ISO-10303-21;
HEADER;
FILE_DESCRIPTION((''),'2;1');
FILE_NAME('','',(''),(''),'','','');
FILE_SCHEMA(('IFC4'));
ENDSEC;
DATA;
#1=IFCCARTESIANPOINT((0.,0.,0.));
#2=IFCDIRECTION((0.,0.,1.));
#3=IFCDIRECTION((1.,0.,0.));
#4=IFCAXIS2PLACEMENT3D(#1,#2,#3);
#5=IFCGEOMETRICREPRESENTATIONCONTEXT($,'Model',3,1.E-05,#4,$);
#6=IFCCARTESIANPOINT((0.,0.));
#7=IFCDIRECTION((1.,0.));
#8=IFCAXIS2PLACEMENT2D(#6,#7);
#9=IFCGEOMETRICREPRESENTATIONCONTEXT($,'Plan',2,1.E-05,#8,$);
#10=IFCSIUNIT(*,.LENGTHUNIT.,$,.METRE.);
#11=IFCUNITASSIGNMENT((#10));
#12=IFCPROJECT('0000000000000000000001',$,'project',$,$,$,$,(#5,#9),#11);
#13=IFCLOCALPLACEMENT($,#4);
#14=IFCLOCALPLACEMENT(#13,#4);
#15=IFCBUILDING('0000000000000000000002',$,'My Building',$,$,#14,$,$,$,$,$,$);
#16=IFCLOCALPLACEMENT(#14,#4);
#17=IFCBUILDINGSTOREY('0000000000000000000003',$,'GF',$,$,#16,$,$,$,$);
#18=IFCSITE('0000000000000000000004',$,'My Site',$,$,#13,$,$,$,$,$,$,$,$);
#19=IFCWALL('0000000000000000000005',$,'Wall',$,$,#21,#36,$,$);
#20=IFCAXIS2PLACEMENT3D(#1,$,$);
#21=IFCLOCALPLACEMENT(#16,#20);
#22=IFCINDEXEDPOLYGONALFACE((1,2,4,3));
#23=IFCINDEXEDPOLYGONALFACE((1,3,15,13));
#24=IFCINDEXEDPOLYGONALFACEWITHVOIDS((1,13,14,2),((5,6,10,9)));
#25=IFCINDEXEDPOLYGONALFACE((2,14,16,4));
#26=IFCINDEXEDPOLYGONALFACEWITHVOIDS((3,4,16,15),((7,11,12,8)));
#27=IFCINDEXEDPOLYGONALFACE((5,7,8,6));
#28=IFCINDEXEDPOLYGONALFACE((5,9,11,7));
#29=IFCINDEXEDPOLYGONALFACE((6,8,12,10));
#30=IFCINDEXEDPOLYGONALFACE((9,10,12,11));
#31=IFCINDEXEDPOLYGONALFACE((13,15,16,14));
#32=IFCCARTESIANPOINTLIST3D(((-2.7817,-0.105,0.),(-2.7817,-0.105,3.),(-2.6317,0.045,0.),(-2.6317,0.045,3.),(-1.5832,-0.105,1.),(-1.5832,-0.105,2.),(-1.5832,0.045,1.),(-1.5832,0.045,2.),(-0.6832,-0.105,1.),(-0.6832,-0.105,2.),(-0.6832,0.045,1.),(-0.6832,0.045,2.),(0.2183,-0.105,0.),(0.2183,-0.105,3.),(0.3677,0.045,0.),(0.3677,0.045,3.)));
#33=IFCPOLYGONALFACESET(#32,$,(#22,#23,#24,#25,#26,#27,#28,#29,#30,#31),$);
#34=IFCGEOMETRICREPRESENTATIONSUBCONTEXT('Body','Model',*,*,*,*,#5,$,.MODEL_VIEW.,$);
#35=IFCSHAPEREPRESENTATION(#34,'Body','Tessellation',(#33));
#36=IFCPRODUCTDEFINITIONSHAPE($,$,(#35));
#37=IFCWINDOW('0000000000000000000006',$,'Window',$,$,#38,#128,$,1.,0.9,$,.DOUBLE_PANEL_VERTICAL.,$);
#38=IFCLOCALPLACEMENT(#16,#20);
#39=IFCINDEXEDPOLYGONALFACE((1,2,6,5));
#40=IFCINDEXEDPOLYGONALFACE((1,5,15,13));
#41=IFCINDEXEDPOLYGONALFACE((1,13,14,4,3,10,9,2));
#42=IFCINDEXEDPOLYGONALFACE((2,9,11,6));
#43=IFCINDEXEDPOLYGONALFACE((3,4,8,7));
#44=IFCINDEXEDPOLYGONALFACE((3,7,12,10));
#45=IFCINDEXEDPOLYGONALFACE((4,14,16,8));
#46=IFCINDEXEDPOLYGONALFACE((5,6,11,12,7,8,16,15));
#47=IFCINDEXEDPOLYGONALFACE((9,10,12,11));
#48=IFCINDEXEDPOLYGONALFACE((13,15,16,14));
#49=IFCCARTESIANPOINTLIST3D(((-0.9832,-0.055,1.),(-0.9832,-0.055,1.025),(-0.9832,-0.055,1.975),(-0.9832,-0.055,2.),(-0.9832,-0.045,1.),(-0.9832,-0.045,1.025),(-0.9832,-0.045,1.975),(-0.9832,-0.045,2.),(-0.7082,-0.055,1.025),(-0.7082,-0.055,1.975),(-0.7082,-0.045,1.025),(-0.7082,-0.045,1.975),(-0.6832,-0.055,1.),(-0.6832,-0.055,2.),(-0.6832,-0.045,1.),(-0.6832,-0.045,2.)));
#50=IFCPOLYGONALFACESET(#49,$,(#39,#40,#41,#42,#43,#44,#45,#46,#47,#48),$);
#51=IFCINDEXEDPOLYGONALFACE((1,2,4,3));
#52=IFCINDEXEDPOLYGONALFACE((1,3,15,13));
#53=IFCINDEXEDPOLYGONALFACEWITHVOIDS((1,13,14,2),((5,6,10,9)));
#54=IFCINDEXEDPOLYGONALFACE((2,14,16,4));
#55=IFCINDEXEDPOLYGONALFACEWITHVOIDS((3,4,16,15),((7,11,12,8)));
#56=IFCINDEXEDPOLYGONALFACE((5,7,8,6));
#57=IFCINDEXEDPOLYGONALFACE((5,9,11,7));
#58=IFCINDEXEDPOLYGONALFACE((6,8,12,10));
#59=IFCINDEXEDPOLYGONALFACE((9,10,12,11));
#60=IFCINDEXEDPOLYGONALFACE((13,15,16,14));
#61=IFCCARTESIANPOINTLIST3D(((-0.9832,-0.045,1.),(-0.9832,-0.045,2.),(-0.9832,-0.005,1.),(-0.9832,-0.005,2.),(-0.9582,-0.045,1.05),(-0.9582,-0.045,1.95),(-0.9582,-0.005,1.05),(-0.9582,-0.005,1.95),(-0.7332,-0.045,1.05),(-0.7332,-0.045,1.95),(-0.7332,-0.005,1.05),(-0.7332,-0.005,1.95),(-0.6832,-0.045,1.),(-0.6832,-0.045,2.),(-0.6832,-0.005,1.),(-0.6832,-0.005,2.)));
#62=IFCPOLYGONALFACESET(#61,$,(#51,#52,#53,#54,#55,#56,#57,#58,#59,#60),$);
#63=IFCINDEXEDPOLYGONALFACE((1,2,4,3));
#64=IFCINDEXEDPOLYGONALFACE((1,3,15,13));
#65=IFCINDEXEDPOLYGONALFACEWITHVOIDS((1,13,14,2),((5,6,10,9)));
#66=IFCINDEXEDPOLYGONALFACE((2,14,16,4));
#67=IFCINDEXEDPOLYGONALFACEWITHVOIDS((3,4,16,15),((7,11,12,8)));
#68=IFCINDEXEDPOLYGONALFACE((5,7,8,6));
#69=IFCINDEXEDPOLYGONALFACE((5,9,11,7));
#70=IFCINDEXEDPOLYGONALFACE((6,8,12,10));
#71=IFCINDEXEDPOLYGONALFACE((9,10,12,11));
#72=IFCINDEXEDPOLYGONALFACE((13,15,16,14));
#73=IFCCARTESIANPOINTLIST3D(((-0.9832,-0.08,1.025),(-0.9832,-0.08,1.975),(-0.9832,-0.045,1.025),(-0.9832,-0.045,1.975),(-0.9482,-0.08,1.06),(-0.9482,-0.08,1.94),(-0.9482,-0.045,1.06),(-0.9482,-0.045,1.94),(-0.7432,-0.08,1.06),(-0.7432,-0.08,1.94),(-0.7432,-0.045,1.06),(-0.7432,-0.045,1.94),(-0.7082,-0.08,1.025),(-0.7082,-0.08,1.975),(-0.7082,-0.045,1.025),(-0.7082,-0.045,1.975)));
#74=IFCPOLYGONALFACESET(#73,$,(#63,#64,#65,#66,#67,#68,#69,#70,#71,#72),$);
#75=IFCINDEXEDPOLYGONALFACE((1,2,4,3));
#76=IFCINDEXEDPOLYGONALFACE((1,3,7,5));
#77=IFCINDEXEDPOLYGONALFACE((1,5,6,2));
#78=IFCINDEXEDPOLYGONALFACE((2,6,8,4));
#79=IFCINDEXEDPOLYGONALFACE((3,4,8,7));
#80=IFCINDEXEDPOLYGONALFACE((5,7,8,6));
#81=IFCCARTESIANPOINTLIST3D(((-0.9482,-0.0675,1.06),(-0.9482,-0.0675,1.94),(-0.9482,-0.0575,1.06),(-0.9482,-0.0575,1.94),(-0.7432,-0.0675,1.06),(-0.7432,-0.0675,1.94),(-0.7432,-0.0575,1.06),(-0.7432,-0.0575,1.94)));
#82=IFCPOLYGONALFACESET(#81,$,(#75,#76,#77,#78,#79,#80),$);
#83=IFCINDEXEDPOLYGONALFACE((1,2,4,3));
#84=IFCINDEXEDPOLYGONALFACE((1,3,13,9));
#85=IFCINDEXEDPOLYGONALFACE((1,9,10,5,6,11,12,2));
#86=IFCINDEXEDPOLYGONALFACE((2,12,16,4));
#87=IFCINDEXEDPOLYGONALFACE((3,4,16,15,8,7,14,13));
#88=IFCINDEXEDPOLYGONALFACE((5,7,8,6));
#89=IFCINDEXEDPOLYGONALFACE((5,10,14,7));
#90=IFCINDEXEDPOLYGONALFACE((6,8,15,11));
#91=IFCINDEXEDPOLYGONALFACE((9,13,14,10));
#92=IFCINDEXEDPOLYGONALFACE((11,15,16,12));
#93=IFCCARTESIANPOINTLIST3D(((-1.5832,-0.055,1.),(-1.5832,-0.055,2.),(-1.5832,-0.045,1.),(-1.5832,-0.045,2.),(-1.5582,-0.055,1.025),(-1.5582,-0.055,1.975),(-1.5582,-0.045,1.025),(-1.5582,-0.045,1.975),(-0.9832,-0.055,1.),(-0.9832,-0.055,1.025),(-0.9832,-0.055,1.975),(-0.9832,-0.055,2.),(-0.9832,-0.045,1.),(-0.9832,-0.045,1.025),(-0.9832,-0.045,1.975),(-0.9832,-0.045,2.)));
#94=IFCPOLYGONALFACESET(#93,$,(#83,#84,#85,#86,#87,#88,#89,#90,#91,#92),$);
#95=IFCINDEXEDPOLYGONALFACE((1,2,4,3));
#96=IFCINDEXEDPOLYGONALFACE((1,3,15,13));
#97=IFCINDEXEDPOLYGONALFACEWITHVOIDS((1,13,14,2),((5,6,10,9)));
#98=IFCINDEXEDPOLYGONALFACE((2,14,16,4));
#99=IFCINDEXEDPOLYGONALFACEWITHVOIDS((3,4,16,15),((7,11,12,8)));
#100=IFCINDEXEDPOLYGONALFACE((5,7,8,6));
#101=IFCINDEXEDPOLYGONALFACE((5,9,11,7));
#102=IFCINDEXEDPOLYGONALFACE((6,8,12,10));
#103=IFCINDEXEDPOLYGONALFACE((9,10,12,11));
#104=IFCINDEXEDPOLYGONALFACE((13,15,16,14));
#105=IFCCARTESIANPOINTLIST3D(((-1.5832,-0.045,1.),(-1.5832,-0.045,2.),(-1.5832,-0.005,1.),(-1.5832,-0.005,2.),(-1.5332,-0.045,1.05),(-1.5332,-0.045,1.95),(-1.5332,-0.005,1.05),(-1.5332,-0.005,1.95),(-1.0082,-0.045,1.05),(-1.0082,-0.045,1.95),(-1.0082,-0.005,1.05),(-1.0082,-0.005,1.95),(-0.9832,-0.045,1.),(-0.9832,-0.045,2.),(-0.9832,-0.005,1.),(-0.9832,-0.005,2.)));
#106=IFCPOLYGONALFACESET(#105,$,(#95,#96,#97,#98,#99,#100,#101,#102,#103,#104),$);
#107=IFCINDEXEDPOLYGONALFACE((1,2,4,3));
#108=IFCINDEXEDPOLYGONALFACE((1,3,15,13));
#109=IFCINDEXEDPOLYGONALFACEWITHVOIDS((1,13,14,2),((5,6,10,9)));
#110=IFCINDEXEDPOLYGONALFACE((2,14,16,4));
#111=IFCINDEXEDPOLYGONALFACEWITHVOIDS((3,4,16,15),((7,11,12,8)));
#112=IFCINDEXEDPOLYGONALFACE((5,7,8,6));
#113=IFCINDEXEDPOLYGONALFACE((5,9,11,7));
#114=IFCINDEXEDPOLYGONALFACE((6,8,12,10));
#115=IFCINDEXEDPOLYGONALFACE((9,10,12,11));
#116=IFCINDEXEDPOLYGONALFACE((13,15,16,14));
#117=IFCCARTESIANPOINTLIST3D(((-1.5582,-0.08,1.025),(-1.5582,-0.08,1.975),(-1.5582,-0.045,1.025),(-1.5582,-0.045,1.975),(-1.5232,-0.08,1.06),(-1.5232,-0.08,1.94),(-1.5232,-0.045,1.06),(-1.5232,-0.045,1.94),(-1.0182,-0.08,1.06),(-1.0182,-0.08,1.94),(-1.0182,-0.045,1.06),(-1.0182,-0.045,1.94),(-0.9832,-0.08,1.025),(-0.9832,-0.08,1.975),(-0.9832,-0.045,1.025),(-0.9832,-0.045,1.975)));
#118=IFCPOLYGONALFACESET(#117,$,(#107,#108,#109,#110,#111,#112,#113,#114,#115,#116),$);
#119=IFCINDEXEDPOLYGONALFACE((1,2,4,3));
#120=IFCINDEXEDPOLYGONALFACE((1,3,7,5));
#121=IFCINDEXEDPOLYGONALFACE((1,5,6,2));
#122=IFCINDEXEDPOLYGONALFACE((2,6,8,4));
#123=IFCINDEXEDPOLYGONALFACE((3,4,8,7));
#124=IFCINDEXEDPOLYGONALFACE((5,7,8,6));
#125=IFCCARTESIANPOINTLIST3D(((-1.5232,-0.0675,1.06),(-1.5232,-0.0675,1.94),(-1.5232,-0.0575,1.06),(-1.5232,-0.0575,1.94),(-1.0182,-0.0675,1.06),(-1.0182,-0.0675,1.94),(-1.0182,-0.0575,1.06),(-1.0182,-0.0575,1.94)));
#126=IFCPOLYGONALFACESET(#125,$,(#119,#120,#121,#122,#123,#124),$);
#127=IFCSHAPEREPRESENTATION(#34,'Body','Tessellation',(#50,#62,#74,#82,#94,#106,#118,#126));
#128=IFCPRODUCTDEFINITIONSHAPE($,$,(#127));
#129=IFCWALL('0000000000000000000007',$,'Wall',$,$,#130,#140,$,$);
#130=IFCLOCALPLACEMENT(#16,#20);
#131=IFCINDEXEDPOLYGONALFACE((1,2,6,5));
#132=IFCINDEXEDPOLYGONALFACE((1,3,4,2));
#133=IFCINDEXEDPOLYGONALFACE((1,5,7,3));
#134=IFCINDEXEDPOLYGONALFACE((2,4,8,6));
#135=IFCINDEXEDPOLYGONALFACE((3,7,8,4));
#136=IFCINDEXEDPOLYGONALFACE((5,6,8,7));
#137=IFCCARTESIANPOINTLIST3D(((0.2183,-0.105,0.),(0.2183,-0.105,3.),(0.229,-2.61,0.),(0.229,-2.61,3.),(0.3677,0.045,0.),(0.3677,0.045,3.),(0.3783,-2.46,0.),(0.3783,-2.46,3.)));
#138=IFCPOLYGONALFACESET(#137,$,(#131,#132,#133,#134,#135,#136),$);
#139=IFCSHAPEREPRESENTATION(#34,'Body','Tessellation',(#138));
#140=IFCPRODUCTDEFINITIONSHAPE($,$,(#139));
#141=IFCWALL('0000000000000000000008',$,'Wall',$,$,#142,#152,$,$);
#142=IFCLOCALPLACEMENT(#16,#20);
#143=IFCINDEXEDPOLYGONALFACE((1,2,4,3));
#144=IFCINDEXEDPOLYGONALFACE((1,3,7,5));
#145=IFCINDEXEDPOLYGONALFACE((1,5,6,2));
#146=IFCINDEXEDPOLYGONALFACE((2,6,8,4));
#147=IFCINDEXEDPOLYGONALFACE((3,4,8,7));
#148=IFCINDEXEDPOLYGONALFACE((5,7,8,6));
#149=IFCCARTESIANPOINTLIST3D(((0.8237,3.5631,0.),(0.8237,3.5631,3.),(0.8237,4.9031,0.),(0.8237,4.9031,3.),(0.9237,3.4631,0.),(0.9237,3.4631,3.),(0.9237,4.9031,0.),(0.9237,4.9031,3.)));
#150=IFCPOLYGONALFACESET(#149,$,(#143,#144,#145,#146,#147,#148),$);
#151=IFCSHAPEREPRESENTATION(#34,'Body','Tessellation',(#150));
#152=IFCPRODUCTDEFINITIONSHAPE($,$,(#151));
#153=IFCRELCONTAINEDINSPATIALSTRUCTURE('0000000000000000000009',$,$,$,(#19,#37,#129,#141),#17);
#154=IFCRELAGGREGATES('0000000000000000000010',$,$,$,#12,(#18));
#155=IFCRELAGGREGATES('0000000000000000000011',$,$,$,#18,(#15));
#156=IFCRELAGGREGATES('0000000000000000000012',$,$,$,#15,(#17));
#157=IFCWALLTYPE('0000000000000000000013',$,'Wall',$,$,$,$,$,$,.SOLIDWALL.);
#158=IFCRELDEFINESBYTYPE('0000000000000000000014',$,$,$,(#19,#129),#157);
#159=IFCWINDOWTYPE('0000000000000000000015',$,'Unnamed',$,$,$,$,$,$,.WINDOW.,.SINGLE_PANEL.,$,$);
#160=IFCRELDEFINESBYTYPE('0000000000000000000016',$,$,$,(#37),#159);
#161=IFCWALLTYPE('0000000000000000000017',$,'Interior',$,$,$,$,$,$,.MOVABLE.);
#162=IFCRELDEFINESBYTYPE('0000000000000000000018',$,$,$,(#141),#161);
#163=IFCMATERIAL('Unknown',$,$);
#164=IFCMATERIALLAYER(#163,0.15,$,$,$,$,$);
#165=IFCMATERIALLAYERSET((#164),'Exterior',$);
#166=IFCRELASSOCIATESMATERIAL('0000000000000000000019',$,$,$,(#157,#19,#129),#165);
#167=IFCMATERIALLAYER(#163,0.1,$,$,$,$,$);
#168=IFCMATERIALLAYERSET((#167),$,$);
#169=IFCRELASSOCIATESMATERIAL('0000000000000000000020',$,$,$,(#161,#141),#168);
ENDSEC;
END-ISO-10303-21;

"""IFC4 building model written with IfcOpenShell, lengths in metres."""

from ifc_helpers import new_model, entity, si_unit, frame, origin_with_axes, origin_2d_with_axis, place, context, subcontext, project, spatial, line, indexed_curve, outline, extrude, shape, source, transform, mapped, material, layer, layer_set, layer_usage, type_object, type_shapes, element, fill, save


model = new_model("IFC4")

# Units and contexts
model_context = context("Model", 3, precision=1e-05, world=origin_with_axes())
plan_context = context("Plan", 2, precision=1e-05, world=origin_2d_with_axis())
body_context_1 = subcontext(model_context, "Body", "Model", "MODEL_VIEW")
body_context_2 = subcontext(plan_context, "Body", "Plan", "PLAN_VIEW")
ifc_project = project(units=[si_unit("LENGTHUNIT", "METRE")], contexts=[model_context, plan_context])

# Site, building, storey
site_placement = place(None, origin_with_axes())
site = spatial("IfcSite", under=ifc_project, at=site_placement, Name="My Site")
building_placement = place(site_placement, origin_with_axes())
building = spatial("IfcBuilding", under=site, at=building_placement, Name="My Building")
storey_placement = place(building_placement, origin_with_axes())
storey = spatial("IfcBuildingStorey", under=building, at=storey_placement, Name="GF")

# Shared definitions
ifc_material = material(Name="Unknown")
ifc_layer_1 = layer(ifc_material, 0.15)
ifc_layer_set_1 = layer_set([ifc_layer_1], Name="Exterior")
wall_type_1 = type_object("IfcWallType", Name="Wall", PredefinedType="SOLIDWALL", material=ifc_layer_set_1)

# Shared definitions
shared_shape_1 = source(origin_with_axes(), body_context_1, "Body", "SweptSolid", [
    extrude(outline(indexed_curve([(0.0, 0.0), (0.9, 0.0), (0.9, 1.0), (0.0, 1.0)], segments=[line(1, 2, 3, 4, 1)])), frame((0.0, -0.6, 0.0), z_axis=(0.0, -1.0, 0.0), x_axis=(1.0, 0.0, 0.0)), (0.0, 0.0, -1.0), 1.2),
])
window_type = type_object("IfcWindowType", Name="Unnamed", PartitioningType="SINGLE_PANEL", PredefinedType="WINDOW")
shared_shape_2 = source(origin_with_axes(), body_context_1, "Body", "SweptSolid", [
    extrude(outline(indexed_curve([(0.3, 0.0), (0.0, 0.0), (0.0, 1.0), (0.3, 1.0), (0.3, 0.975), (0.025, 0.975), (0.025, 0.025), (0.3, 0.025)], segments=[line(1, 2, 3, 4, 5, 6, 7, 8, 1)])), frame((0.0, 0.09, 0.0), z_axis=(0.0, -1.0, 0.0), x_axis=(1.0, 0.0, 0.0)), (0.0, 0.0, -1.0), 0.01),
    extrude(outline(indexed_curve([(0.0, 0.0), (0.3, 0.0), (0.3, 1.0), (0.0, 1.0)], segments=[line(1, 2, 3, 4, 1)]), holes=[indexed_curve([(0.05, 0.05), (0.275, 0.05), (0.275, 0.95), (0.05, 0.95)], segments=[line(1, 2, 3, 4, 1)])]), frame((0.0, 0.05, 0.0), z_axis=(0.0, -1.0, 0.0), x_axis=(1.0, 0.0, 0.0)), (0.0, 0.0, -1.0), 0.04),
    extrude(outline(indexed_curve([(0.0, 0.0), (0.275, 0.0), (0.275, 0.95), (0.0, 0.95)], segments=[line(1, 2, 3, 4, 1)]), holes=[indexed_curve([(0.035, 0.035), (0.24, 0.035), (0.24, 0.915), (0.035, 0.915)], segments=[line(1, 2, 3, 4, 1)])]), frame((0.025, 0.09, 0.025), z_axis=(0.0, -1.0, 0.0), x_axis=(1.0, 0.0, 0.0)), (0.0, 0.0, -1.0), 0.035),
    extrude(outline(indexed_curve([(0.035, 0.035), (0.24, 0.035), (0.24, 0.915), (0.035, 0.915)], segments=[line(1, 2, 3, 4, 1)])), frame((0.025, 0.1025, 0.025), z_axis=(0.0, -1.0, 0.0), x_axis=(1.0, 0.0, 0.0)), (0.0, 0.0, -1.0), 0.01),
    extrude(outline(indexed_curve([(0.0, 1.0), (0.6, 1.0), (0.6, 0.0), (0.0, 0.0), (0.0, 0.025), (0.575, 0.025), (0.575, 0.975), (0.0, 0.975)], segments=[line(1, 2, 3, 4, 5, 6, 7, 8, 1)])), frame((0.3, 0.09, 0.0), z_axis=(0.0, -1.0, 0.0), x_axis=(1.0, 0.0, 0.0)), (0.0, 0.0, -1.0), 0.01),
    extrude(outline(indexed_curve([(0.0, 0.0), (0.6, 0.0), (0.6, 1.0), (0.0, 1.0)], segments=[line(1, 2, 3, 4, 1)]), holes=[indexed_curve([(0.025, 0.05), (0.55, 0.05), (0.55, 0.95), (0.025, 0.95)], segments=[line(1, 2, 3, 4, 1)])]), frame((0.3, 0.05, 0.0), z_axis=(0.0, -1.0, 0.0), x_axis=(1.0, 0.0, 0.0)), (0.0, 0.0, -1.0), 0.04),
    extrude(outline(indexed_curve([(0.0, 0.0), (0.575, 0.0), (0.575, 0.95), (0.0, 0.95)], segments=[line(1, 2, 3, 4, 1)]), holes=[indexed_curve([(0.035, 0.035), (0.54, 0.035), (0.54, 0.915), (0.035, 0.915)], segments=[line(1, 2, 3, 4, 1)])]), frame((0.3, 0.09, 0.025), z_axis=(0.0, -1.0, 0.0), x_axis=(1.0, 0.0, 0.0)), (0.0, 0.0, -1.0), 0.035),
    extrude(outline(indexed_curve([(0.035, 0.035), (0.54, 0.035), (0.54, 0.915), (0.035, 0.915)], segments=[line(1, 2, 3, 4, 1)])), frame((0.3, 0.1025, 0.025), z_axis=(0.0, -1.0, 0.0), x_axis=(1.0, 0.0, 0.0)), (0.0, 0.0, -1.0), 0.01),
])
shared_shape_3 = source(origin_with_axes(), body_context_2, "Body", "Curve2D", [
    entity("IfcIndexedPolyCurve", entity("IfcCartesianPointList2D", [[0.05, 0.05], [0.275, 0.05]])),
    entity("IfcIndexedPolyCurve", entity("IfcCartesianPointList2D", [[0.0, 0.1], [0.025, 0.1], [0.025, 0.09], [0.05, 0.09], [0.05, 0.05], [0.0, 0.05]]), [entity("IfcLineIndex", [1, 2, 3, 4, 5, 6, 1])]),
    entity("IfcIndexedPolyCurve", entity("IfcCartesianPointList2D", [[0.3, 0.1], [0.3, 0.1], [0.3, 0.09], [0.275, 0.09], [0.275, 0.05], [0.3, 0.05]])),
    entity("IfcIndexedPolyCurve", entity("IfcCartesianPointList2D", [[0.025, 0.09], [0.06, 0.09], [0.06, 0.125], [0.025, 0.125]]), [entity("IfcLineIndex", [1, 2, 3, 4, 1])]),
    entity("IfcIndexedPolyCurve", entity("IfcCartesianPointList2D", [[0.3, 0.09], [0.265, 0.09], [0.265, 0.125], [0.3, 0.125]]), [entity("IfcLineIndex", [1, 2, 3, 4, 1])]),
    entity("IfcIndexedPolyCurve", entity("IfcCartesianPointList2D", [[0.06, 0.09], [0.265, 0.09]])),
    entity("IfcIndexedPolyCurve", entity("IfcCartesianPointList2D", [[0.06, 0.125], [0.265, 0.125]])),
    entity("IfcIndexedPolyCurve", entity("IfcCartesianPointList2D", [[0.06, 0.1075], [0.265, 0.1075]])),
    entity("IfcIndexedPolyCurve", entity("IfcCartesianPointList2D", [[0.325, 0.05], [0.85, 0.05]])),
    entity("IfcIndexedPolyCurve", entity("IfcCartesianPointList2D", [[0.3, 0.1], [0.3, 0.1], [0.3, 0.09], [0.325, 0.09], [0.325, 0.05], [0.3, 0.05]])),
    entity("IfcIndexedPolyCurve", entity("IfcCartesianPointList2D", [[0.9, 0.1], [0.875, 0.1], [0.875, 0.09], [0.85, 0.09], [0.85, 0.05], [0.9, 0.05]]), [entity("IfcLineIndex", [1, 2, 3, 4, 5, 6, 1])]),
    entity("IfcIndexedPolyCurve", entity("IfcCartesianPointList2D", [[0.3, 0.09], [0.335, 0.09], [0.335, 0.125], [0.3, 0.125]]), [entity("IfcLineIndex", [1, 2, 3, 4, 1])]),
    entity("IfcIndexedPolyCurve", entity("IfcCartesianPointList2D", [[0.875, 0.09], [0.84, 0.09], [0.84, 0.125], [0.875, 0.125]]), [entity("IfcLineIndex", [1, 2, 3, 4, 1])]),
    entity("IfcIndexedPolyCurve", entity("IfcCartesianPointList2D", [[0.335, 0.09], [0.84, 0.09]])),
    entity("IfcIndexedPolyCurve", entity("IfcCartesianPointList2D", [[0.335, 0.125], [0.84, 0.125]])),
    entity("IfcIndexedPolyCurve", entity("IfcCartesianPointList2D", [[0.335, 0.1075], [0.84, 0.1075]])),
])
type_shapes(window_type, [shared_shape_2, shared_shape_3])

# Wall, opening, window
ifc_layer_usage_1 = layer_usage(ifc_layer_set_1, "AXIS2", "POSITIVE", 0.0)
wall_1_placement = place(storey_placement, frame((-2.7817, -0.105, 0.0), z_axis=(0.0, 0.0, 1.0), x_axis=(1.0, 0.0, 0.0)))
wall_1 = element("IfcWall", 1, at=wall_1_placement, inside=storey, type_object=wall_type_1, material=ifc_layer_usage_1, Name="Wall", context=body_context_1, shape_type="SweptSolid", body=[
    extrude(outline(indexed_curve([(0.0, 0.0), (0.15, 0.15), (3.1494, 0.15), (3.0, 0.0)], segments=[line(1, 2, 3, 4, 1)])), origin_with_axes(), (0.0, 0.0, 1.0), 3.0),
])
opening_1_placement = place(wall_1_placement, frame((2.0985, 0.15, 1.0), z_axis=(0.0, 0.0, 1.0), x_axis=(-1.0, 0.0, 0.0)))
opening_1 = element("IfcOpeningElement", 2, at=opening_1_placement, cuts=wall_1, PredefinedType="OPENING", context=body_context_1, shape_type="MappedRepresentation", body=[
    mapped(shared_shape_1, transform((0.0, 0.0, 0.0), x_axis=(1.0, 0.0, 0.0), y_axis=(0.0, 1.0, 0.0), z_axis=(0.0, 0.0, 1.0), scale=1.0)),
])
window_1_placement = place(opening_1_placement, origin_with_axes())
window_1 = element("IfcWindow", 3, at=window_1_placement, inside=storey, type_object=window_type, Name="Window", OverallHeight=1.0, OverallWidth=0.9, PartitioningType="DOUBLE_PANEL_VERTICAL", shapes=[
    shape(body_context_1, "Body", "MappedRepresentation", [mapped(shared_shape_2, transform((0.0, 0.0, 0.0), x_axis=(1.0, 0.0, 0.0), y_axis=(0.0, 1.0, 0.0), z_axis=(0.0, 0.0, 1.0), scale=1.0))]),
    shape(body_context_2, "Body", "MappedRepresentation", [mapped(shared_shape_3, transform((0.0, 0.0, 0.0), x_axis=(1.0, 0.0, 0.0), y_axis=(0.0, 1.0, 0.0), z_axis=(0.0, 0.0, 1.0), scale=1.0))]),
])
fill(opening_1, window_1)

# Walls
ifc_layer_usage_2 = layer_usage(ifc_layer_set_1, "AXIS2", "POSITIVE", 0.0)
wall_2_placement = place(storey_placement, frame((0.2183, -0.105, 0.0), z_axis=(0.0, 0.0, 1.0), x_axis=(0.004245, -0.999991, 0.0)))
element("IfcWall", 4, at=wall_2_placement, inside=storey, type_object=wall_type_1, material=ifc_layer_usage_2, Name="Wall", context=body_context_1, shape_type="SweptSolid", body=[
    extrude(outline(indexed_curve([(0.0, 0.0), (-0.1494, 0.15), (2.3557, 0.15), (2.505, 0.0)], segments=[line(1, 2, 3, 4, 1)])), origin_with_axes(), (0.0, 0.0, 1.0), 3.0),
])
ifc_layer_2 = layer(ifc_material, 0.1)
ifc_layer_set_2 = layer_set([ifc_layer_2])
ifc_layer_usage_3 = layer_usage(ifc_layer_set_2, "AXIS2", "POSITIVE", 0.0)
wall_type_2 = type_object("IfcWallType", Name="Interior", PredefinedType="MOVABLE", material=ifc_layer_set_2)
wall_3_placement = place(storey_placement, frame((0.8237, 4.9031, 0.0), z_axis=(0.0, 0.0, 1.0), x_axis=(0.0, -1.0, 0.0)))
element("IfcWall", 5, at=wall_3_placement, inside=storey, type_object=wall_type_2, material=ifc_layer_usage_3, Name="Wall", context=body_context_1, shape_type="SweptSolid", body=[
    extrude(outline(indexed_curve([(0.0, 0.0), (0.0, 0.1), (1.44, 0.1), (1.34, 0.0)], segments=[line(1, 2, 3, 4, 1)])), origin_with_axes(), (0.0, 0.0, 1.0), 3.0),
])

save(model, "model.ifc")
